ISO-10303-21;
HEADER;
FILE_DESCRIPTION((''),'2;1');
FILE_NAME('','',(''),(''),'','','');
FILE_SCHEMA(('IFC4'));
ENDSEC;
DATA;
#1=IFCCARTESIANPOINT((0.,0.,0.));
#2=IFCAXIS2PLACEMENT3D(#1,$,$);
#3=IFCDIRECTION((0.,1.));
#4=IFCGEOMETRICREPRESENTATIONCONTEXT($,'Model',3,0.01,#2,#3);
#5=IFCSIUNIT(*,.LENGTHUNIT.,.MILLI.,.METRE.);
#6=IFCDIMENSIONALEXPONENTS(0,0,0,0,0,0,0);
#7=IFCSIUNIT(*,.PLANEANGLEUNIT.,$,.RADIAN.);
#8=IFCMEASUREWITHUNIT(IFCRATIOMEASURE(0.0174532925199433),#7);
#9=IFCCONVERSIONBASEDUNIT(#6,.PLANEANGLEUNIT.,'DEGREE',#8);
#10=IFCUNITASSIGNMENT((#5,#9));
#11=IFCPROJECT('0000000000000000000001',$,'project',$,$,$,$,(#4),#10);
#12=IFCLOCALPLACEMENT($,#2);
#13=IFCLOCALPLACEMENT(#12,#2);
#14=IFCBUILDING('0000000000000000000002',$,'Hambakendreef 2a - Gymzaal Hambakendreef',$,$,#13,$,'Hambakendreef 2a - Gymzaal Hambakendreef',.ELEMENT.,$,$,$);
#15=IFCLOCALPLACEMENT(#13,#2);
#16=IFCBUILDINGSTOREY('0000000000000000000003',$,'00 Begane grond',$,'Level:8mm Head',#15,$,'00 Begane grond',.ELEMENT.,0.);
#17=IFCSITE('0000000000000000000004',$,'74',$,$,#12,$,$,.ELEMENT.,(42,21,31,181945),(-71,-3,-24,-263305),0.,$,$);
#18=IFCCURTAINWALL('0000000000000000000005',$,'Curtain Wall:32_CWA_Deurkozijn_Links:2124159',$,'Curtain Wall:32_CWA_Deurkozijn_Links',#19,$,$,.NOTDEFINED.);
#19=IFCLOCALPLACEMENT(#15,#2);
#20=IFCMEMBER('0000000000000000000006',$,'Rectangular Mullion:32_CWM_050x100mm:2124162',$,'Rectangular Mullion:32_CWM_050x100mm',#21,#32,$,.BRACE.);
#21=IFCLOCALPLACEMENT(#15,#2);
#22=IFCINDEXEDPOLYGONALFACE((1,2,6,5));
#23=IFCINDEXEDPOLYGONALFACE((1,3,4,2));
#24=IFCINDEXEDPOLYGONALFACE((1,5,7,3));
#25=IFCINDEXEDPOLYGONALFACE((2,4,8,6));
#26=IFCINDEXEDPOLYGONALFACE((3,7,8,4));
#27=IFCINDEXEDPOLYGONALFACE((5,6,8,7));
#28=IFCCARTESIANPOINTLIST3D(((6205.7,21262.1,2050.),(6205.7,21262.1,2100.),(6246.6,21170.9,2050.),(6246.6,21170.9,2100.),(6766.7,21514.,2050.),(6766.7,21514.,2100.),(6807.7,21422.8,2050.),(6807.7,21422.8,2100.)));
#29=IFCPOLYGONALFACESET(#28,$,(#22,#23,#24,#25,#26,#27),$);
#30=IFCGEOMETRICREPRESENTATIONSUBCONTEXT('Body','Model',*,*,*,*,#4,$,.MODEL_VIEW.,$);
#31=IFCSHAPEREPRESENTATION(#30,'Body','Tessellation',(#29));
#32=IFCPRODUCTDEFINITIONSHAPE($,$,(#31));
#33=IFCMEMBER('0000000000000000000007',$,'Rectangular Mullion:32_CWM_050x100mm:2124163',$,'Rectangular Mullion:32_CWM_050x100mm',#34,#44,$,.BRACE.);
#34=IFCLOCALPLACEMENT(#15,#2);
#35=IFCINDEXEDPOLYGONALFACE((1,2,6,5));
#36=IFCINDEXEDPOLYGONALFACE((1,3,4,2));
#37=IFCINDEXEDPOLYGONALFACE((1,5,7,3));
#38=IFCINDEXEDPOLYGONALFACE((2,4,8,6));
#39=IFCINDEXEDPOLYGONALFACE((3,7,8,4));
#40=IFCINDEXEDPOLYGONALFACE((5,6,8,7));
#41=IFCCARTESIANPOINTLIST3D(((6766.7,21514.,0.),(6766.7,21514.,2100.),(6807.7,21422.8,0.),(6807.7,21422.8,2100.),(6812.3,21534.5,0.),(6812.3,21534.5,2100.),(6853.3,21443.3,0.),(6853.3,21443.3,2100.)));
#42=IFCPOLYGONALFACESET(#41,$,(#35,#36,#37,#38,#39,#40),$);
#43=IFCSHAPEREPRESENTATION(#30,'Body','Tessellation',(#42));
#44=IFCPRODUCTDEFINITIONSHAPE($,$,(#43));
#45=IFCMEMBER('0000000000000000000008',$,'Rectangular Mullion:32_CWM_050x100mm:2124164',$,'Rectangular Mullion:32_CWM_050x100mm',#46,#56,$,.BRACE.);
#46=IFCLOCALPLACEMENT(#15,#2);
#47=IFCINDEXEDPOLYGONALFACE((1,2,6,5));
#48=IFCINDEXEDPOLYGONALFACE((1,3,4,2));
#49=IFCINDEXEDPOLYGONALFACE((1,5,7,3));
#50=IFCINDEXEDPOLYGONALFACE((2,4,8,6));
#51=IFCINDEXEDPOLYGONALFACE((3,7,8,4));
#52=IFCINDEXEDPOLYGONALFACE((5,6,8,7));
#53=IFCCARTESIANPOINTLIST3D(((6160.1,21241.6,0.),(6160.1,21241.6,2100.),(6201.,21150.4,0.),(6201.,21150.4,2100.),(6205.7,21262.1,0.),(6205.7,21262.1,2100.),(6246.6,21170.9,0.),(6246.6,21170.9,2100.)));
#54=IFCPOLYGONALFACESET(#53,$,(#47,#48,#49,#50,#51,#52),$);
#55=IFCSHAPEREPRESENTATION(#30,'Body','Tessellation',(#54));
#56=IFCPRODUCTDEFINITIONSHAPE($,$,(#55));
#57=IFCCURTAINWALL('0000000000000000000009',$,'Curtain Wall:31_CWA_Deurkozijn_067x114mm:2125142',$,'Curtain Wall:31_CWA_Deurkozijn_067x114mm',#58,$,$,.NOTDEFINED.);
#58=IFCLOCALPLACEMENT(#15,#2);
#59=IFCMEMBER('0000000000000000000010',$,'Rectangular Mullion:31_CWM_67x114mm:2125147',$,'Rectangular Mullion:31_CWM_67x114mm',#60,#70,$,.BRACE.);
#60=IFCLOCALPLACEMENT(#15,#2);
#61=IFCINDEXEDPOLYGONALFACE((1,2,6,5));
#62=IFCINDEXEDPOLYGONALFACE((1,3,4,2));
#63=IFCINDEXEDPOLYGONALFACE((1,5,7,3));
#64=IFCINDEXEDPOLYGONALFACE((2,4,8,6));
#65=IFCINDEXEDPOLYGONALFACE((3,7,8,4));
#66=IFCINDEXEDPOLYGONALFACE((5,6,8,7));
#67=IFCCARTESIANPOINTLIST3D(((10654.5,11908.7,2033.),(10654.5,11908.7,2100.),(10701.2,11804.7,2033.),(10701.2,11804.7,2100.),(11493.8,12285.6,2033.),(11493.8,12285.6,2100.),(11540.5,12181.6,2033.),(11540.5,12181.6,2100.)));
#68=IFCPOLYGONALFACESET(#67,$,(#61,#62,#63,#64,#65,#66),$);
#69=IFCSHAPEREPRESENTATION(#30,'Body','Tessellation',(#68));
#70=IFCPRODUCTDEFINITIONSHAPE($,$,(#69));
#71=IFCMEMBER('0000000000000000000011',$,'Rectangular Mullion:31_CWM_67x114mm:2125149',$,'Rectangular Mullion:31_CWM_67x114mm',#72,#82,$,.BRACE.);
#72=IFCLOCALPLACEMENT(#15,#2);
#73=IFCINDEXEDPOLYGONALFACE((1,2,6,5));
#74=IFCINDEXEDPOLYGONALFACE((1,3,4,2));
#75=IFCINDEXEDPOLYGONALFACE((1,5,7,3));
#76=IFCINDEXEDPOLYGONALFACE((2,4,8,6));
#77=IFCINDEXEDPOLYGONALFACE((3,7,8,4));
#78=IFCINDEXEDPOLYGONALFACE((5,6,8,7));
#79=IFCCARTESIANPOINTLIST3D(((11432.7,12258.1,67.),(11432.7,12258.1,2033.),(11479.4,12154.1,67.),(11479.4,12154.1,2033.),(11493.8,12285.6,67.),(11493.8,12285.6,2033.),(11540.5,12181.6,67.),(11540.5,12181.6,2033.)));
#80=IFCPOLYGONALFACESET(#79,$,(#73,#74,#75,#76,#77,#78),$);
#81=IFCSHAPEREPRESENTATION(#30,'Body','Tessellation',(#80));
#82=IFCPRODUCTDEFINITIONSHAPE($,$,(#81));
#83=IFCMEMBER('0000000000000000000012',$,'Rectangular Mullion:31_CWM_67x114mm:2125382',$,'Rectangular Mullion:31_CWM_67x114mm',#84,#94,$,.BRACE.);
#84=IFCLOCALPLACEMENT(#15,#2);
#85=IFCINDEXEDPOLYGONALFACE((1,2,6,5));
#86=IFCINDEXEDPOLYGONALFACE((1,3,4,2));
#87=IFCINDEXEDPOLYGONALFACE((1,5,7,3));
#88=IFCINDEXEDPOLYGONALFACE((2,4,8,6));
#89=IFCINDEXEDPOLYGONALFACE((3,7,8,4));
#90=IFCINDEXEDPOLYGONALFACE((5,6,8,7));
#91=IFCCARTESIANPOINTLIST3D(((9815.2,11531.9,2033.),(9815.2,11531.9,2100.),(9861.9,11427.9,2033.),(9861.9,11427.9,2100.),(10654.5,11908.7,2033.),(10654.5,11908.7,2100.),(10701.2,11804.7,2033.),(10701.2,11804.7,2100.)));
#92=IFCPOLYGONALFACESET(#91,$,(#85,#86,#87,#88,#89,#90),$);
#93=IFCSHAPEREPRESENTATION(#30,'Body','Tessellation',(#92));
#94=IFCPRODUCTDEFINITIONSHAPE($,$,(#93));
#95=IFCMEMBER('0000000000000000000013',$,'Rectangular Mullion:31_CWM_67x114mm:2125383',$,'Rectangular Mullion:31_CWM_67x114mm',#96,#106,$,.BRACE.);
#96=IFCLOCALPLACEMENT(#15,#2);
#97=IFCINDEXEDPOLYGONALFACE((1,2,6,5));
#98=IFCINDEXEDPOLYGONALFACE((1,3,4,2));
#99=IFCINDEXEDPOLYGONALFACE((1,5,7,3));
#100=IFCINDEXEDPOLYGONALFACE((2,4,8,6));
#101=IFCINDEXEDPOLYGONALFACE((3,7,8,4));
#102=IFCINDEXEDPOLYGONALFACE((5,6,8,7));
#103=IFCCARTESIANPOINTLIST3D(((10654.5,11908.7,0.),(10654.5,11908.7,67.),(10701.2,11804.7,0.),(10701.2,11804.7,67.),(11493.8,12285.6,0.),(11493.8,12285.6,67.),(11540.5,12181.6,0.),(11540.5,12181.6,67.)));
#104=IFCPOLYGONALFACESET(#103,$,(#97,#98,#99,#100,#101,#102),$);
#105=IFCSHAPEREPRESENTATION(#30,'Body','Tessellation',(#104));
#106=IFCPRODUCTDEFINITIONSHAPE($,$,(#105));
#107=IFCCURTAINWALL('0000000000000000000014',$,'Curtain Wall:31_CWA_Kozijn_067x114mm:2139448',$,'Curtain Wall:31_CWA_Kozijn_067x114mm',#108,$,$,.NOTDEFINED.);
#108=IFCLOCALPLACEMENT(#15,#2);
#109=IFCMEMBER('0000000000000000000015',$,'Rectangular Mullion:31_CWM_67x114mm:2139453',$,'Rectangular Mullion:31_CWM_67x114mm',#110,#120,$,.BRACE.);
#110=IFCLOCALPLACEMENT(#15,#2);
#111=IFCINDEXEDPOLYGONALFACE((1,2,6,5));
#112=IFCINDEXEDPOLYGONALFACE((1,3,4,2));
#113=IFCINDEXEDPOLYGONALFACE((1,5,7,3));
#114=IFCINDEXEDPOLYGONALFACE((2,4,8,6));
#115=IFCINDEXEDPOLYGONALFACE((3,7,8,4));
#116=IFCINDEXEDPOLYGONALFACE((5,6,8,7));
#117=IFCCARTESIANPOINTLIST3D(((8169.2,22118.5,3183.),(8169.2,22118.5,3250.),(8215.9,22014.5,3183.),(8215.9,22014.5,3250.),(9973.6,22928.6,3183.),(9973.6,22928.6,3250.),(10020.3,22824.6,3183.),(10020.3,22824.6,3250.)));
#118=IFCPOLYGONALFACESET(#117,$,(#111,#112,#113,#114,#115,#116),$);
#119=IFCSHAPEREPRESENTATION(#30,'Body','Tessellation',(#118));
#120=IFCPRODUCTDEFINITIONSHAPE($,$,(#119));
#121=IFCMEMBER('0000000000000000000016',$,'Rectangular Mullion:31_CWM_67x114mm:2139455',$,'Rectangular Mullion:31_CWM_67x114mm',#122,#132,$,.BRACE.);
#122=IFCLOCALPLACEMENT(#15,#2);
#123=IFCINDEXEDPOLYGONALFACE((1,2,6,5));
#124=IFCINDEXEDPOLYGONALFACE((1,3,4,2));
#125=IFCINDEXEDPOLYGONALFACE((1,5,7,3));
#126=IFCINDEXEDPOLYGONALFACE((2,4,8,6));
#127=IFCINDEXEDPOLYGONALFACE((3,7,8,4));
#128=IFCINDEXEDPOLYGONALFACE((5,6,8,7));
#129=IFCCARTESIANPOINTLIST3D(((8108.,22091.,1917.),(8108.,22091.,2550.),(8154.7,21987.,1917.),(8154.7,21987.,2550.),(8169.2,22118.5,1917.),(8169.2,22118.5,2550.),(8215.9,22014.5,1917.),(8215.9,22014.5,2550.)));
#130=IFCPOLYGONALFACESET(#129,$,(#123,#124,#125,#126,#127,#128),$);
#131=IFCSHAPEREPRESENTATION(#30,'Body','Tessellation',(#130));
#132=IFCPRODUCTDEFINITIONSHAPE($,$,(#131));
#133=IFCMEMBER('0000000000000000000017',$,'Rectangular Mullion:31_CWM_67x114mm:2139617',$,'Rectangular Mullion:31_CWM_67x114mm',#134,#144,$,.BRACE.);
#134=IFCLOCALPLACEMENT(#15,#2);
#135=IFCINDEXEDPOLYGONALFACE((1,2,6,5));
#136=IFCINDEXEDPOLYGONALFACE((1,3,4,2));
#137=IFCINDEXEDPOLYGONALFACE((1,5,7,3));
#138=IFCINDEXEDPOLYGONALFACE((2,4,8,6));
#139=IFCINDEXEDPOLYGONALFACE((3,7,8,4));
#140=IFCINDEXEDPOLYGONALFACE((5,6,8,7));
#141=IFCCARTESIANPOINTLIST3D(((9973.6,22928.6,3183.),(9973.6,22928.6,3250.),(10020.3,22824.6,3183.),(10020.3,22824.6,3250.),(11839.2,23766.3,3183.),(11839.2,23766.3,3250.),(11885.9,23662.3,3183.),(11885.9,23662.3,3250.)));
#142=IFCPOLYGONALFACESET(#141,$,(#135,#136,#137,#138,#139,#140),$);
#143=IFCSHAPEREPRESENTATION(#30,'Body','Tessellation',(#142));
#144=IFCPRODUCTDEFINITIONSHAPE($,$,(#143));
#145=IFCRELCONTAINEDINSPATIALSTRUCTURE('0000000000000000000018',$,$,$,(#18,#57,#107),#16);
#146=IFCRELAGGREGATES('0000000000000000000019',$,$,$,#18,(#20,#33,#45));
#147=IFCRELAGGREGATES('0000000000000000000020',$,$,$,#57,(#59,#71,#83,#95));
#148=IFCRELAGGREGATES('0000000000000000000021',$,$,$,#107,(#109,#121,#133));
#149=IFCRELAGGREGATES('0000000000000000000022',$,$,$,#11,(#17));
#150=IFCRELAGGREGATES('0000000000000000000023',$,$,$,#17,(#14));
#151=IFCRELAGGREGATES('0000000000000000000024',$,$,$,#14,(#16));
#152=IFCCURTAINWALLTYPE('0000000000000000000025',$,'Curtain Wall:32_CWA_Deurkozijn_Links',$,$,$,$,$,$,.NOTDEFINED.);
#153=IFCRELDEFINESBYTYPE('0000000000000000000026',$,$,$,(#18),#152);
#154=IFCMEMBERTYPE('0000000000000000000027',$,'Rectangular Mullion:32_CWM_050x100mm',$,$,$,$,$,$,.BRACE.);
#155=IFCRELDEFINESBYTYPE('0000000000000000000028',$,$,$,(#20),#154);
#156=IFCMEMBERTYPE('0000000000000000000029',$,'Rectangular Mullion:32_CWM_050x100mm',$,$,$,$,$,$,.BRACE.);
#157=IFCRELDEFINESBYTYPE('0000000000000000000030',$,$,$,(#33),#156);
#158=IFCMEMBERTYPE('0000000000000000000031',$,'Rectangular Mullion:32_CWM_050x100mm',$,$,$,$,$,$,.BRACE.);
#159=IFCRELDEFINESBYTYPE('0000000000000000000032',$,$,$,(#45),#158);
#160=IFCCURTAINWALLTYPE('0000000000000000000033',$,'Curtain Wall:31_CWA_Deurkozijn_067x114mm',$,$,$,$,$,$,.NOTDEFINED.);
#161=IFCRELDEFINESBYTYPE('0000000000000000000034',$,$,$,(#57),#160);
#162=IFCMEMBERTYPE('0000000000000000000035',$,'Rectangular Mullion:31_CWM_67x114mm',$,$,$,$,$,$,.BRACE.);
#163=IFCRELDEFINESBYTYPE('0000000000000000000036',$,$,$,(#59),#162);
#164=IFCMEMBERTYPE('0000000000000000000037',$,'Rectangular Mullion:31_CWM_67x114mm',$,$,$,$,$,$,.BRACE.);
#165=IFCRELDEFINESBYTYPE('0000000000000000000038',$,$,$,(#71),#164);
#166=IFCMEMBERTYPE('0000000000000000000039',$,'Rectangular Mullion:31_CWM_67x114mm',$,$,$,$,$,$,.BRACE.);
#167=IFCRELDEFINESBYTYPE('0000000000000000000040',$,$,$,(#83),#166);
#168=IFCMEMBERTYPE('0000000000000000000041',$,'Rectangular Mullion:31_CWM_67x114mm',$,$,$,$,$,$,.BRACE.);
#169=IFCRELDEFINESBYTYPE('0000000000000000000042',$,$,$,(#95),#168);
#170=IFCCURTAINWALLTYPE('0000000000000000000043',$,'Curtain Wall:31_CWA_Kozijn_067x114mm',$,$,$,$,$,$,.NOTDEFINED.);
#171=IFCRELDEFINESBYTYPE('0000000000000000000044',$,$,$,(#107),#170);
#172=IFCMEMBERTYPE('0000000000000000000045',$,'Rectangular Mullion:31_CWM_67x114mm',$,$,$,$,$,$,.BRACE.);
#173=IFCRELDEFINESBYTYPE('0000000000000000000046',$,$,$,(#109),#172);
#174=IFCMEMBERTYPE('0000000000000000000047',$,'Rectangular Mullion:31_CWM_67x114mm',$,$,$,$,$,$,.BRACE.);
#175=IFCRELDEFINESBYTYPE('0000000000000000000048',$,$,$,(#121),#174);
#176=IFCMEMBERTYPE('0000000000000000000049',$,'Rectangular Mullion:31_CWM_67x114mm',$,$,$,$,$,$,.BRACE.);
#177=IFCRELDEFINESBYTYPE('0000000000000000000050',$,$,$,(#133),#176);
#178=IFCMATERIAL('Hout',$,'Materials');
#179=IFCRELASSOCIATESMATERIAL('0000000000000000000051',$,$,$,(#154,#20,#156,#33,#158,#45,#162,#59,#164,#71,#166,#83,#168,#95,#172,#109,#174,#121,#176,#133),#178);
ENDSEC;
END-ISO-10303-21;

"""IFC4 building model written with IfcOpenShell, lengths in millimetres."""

from ifc_helpers import new_model, entity, si_unit, converted_unit, direction, frame, origin, place, context, subcontext, project, spatial, indexed_curve, outline, extrude, source, transform, mapped, material, type_object, type_shapes, element, aggregate, save


model = new_model("IFC4")

# Units and contexts
model_context = context("Model", 3, precision=0.01, world=origin(), true_north=direction((0.0, 1.0)))
body_context = subcontext(model_context, "Body", "Model", "MODEL_VIEW")
ifc_project = project(units=[si_unit("LENGTHUNIT", "METRE", prefix="MILLI"), converted_unit("PLANEANGLEUNIT", "DEGREE", entity("IfcRatioMeasure", 0.0174532925199433), si_unit("PLANEANGLEUNIT", "RADIAN"), dimensions=[0, 0, 0, 0, 0, 0, 0])], contexts=[model_context])

# Site, building, storey
site_placement = place(None, origin())
site = spatial("IfcSite", under=ifc_project, at=site_placement, Name="74", CompositionType="ELEMENT", RefLatitude=(42, 21, 31, 181945), RefLongitude=(-71, -3, -24, -263305), RefElevation=0.0)
building_placement = place(site_placement, origin())
building = spatial("IfcBuilding", under=site, at=building_placement, Name="Hambakendreef 2a - Gymzaal Hambakendreef", LongName="Hambakendreef 2a - Gymzaal Hambakendreef", CompositionType="ELEMENT")
storey_placement = place(building_placement, origin())
storey = spatial("IfcBuildingStorey", under=building, at=storey_placement, Name="00 Begane grond", ObjectType="Level:8mm Head", LongName="00 Begane grond", CompositionType="ELEMENT", Elevation=0.0)

# Curtain walls, members
curtain_wall_type_1 = type_object("IfcCurtainWallType", Name="Curtain Wall:32_CWA_Deurkozijn_Links", PredefinedType="NOTDEFINED")
curtain_wall_1_placement = place(storey_placement, origin())
curtain_wall_1 = element("IfcCurtainWall", 1, at=curtain_wall_1_placement, inside=storey, type_object=curtain_wall_type_1, Name="Curtain Wall:32_CWA_Deurkozijn_Links:2124159", ObjectType="Curtain Wall:32_CWA_Deurkozijn_Links", PredefinedType="NOTDEFINED")
ifc_material_1 = material(Name="Hout", Category="Materials")
member_type_1 = type_object("IfcMemberType", Name="Rectangular Mullion:32_CWM_050x100mm", PredefinedType="BRACE", material=ifc_material_1)
shared_shape_1 = source(origin(), body_context, "Body", "SweptSolid", [
    extrude(outline(indexed_curve([(-50.0, -25.0), (50.0, -25.0), (50.0, 25.0), (-50.0, 25.0), (-50.0, -25.0)], self_intersect=False)), frame((-25.0, 0.0, -615.0), z_axis=(0.0, 0.0, 1.0), x_axis=(0.0, -1.0, 0.0)), (0.0, 0.0, 1.0), 615.0),
])
type_shapes(member_type_1, [shared_shape_1])
member_1_placement = place(storey_placement, frame((6787.2, 21468.4, 2100.0), z_axis=(0.91227, 0.40959, 0.0), x_axis=(0.0, 0.0, 1.0)))
member_1 = element("IfcMember", 2, at=member_1_placement, type_object=member_type_1, material=ifc_material_1, Name="Rectangular Mullion:32_CWM_050x100mm:2124162", ObjectType="Rectangular Mullion:32_CWM_050x100mm", PredefinedType="BRACE", context=body_context, shape_type="MappedRepresentation", body=[
    mapped(shared_shape_1, transform((0.0, 0.0, 0.0), scale=1.0)),
])
member_type_2 = type_object("IfcMemberType", Name="Rectangular Mullion:32_CWM_050x100mm", PredefinedType="BRACE", material=ifc_material_1)
shared_shape_2 = source(origin(), body_context, "Body", "SweptSolid", [
    extrude(outline(indexed_curve([(-50.0, -25.0), (50.0, -25.0), (50.0, 25.0), (-50.0, 25.0), (-50.0, -25.0)], self_intersect=False)), frame((-25.0, 0.0, -2100.0), z_axis=(0.0, 0.0, 1.0), x_axis=(0.0, -1.0, 0.0)), (0.0, 0.0, 1.0), 2100.0),
])
type_shapes(member_type_2, [shared_shape_2])
member_2_placement = place(storey_placement, frame((6832.8, 21488.9, 0.0), z_axis=(0.0, 0.0, -1.0), x_axis=(0.91227, 0.40959, 0.0)))
member_2 = element("IfcMember", 3, at=member_2_placement, type_object=member_type_2, material=ifc_material_1, Name="Rectangular Mullion:32_CWM_050x100mm:2124163", ObjectType="Rectangular Mullion:32_CWM_050x100mm", PredefinedType="BRACE", context=body_context, shape_type="MappedRepresentation", body=[
    mapped(shared_shape_2, transform((0.0, 0.0, 0.0), scale=1.0)),
])
member_type_3 = type_object("IfcMemberType", Name="Rectangular Mullion:32_CWM_050x100mm", PredefinedType="BRACE", material=ifc_material_1)
shared_shape_3 = source(origin(), body_context, "Body", "SweptSolid", [
    extrude(outline(indexed_curve([(-50.0, -25.0), (50.0, -25.0), (50.0, 25.0), (-50.0, 25.0), (-50.0, -25.0)], self_intersect=False)), frame((-25.0, 0.0, -2100.0), z_axis=(0.0, 0.0, 1.0), x_axis=(0.0, -1.0, 0.0)), (0.0, 0.0, 1.0), 2100.0),
])
type_shapes(member_type_3, [shared_shape_3])
member_3_placement = place(storey_placement, frame((6180.5, 21196.0, 2100.0), z_axis=(0.0, 0.0, 1.0), x_axis=(-0.91227, -0.40959, 0.0)))
member_3 = element("IfcMember", 4, at=member_3_placement, type_object=member_type_3, material=ifc_material_1, Name="Rectangular Mullion:32_CWM_050x100mm:2124164", ObjectType="Rectangular Mullion:32_CWM_050x100mm", PredefinedType="BRACE", context=body_context, shape_type="MappedRepresentation", body=[
    mapped(shared_shape_3, transform((0.0, 0.0, 0.0), scale=1.0)),
])
curtain_wall_type_2 = type_object("IfcCurtainWallType", Name="Curtain Wall:31_CWA_Deurkozijn_067x114mm", PredefinedType="NOTDEFINED")
curtain_wall_2_placement = place(storey_placement, origin())
curtain_wall_2 = element("IfcCurtainWall", 5, at=curtain_wall_2_placement, inside=storey, type_object=curtain_wall_type_2, Name="Curtain Wall:31_CWA_Deurkozijn_067x114mm:2125142", ObjectType="Curtain Wall:31_CWA_Deurkozijn_067x114mm", PredefinedType="NOTDEFINED")
member_type_4 = type_object("IfcMemberType", Name="Rectangular Mullion:31_CWM_67x114mm", PredefinedType="BRACE", material=ifc_material_1)
shared_shape_4 = source(origin(), body_context, "Body", "SweptSolid", [
    extrude(outline(indexed_curve([(-57.0, -33.5), (57.0, -33.5), (57.0, 33.5), (-57.0, 33.5), (-57.0, -33.5)], self_intersect=False)), frame((-33.5, 0.0, -920.0), z_axis=(0.0, 0.0, 1.0), x_axis=(0.0, -1.0, 0.0)), (0.0, 0.0, 1.0), 920.0),
])
type_shapes(member_type_4, [shared_shape_4])
member_4_placement = place(storey_placement, frame((11517.1, 12233.6, 2100.0), z_axis=(0.91227, 0.40959, 0.0), x_axis=(0.0, 0.0, 1.0)))
member_4 = element("IfcMember", 6, at=member_4_placement, type_object=member_type_4, material=ifc_material_1, Name="Rectangular Mullion:31_CWM_67x114mm:2125147", ObjectType="Rectangular Mullion:31_CWM_67x114mm", PredefinedType="BRACE", context=body_context, shape_type="MappedRepresentation", body=[
    mapped(shared_shape_4, transform((0.0, 0.0, 0.0), scale=1.0)),
])
member_type_5 = type_object("IfcMemberType", Name="Rectangular Mullion:31_CWM_67x114mm", PredefinedType="BRACE", material=ifc_material_1)
shared_shape_5 = source(origin(), body_context, "Body", "SweptSolid", [
    extrude(outline(indexed_curve([(-57.0, -33.5), (57.0, -33.5), (57.0, 33.5), (-57.0, 33.5), (-57.0, -33.5)], self_intersect=False)), frame((-33.5, 0.0, -1966.0), z_axis=(0.0, 0.0, 1.0), x_axis=(0.0, -1.0, 0.0)), (0.0, 0.0, 1.0), 1966.0),
])
type_shapes(member_type_5, [shared_shape_5])
member_5_placement = place(storey_placement, frame((11517.1, 12233.6, 67.0), z_axis=(0.0, 0.0, -1.0), x_axis=(0.91227, 0.40959, 0.0)))
member_5 = element("IfcMember", 7, at=member_5_placement, type_object=member_type_5, material=ifc_material_1, Name="Rectangular Mullion:31_CWM_67x114mm:2125149", ObjectType="Rectangular Mullion:31_CWM_67x114mm", PredefinedType="BRACE", context=body_context, shape_type="MappedRepresentation", body=[
    mapped(shared_shape_5, transform((0.0, 0.0, 0.0), scale=1.0)),
])
member_type_6 = type_object("IfcMemberType", Name="Rectangular Mullion:31_CWM_67x114mm", PredefinedType="BRACE", material=ifc_material_1)
shared_shape_6 = source(origin(), body_context, "Body", "SweptSolid", [
    extrude(outline(indexed_curve([(-57.0, -33.5), (57.0, -33.5), (57.0, 33.5), (-57.0, 33.5), (-57.0, -33.5)], self_intersect=False)), frame((-33.5, 0.0, -920.0), z_axis=(0.0, 0.0, 1.0), x_axis=(0.0, -1.0, 0.0)), (0.0, 0.0, 1.0), 920.0),
])
type_shapes(member_type_6, [shared_shape_6])
member_6_placement = place(storey_placement, frame((10677.9, 11856.7, 2100.0), z_axis=(0.91227, 0.40959, 0.0), x_axis=(0.0, 0.0, 1.0)))
member_6 = element("IfcMember", 8, at=member_6_placement, type_object=member_type_6, material=ifc_material_1, Name="Rectangular Mullion:31_CWM_67x114mm:2125382", ObjectType="Rectangular Mullion:31_CWM_67x114mm", PredefinedType="BRACE", context=body_context, shape_type="MappedRepresentation", body=[
    mapped(shared_shape_6, transform((0.0, 0.0, 0.0), scale=1.0)),
])
member_type_7 = type_object("IfcMemberType", Name="Rectangular Mullion:31_CWM_67x114mm", PredefinedType="BRACE", material=ifc_material_1)
shared_shape_7 = source(origin(), body_context, "Body", "SweptSolid", [
    extrude(outline(indexed_curve([(-57.0, -33.5), (57.0, -33.5), (57.0, 33.5), (-57.0, 33.5), (-57.0, -33.5)], self_intersect=False)), frame((-33.5, 0.0, -920.0), z_axis=(0.0, 0.0, 1.0), x_axis=(0.0, -1.0, 0.0)), (0.0, 0.0, 1.0), 920.0),
])
type_shapes(member_type_7, [shared_shape_7])
member_7_placement = place(storey_placement, frame((10677.9, 11856.7, 0.0), z_axis=(-0.91227, -0.40959, 0.0), x_axis=(0.0, 0.0, -1.0)))
member_7 = element("IfcMember", 9, at=member_7_placement, type_object=member_type_7, material=ifc_material_1, Name="Rectangular Mullion:31_CWM_67x114mm:2125383", ObjectType="Rectangular Mullion:31_CWM_67x114mm", PredefinedType="BRACE", context=body_context, shape_type="MappedRepresentation", body=[
    mapped(shared_shape_7, transform((0.0, 0.0, 0.0), scale=1.0)),
])
curtain_wall_type_3 = type_object("IfcCurtainWallType", Name="Curtain Wall:31_CWA_Kozijn_067x114mm", PredefinedType="NOTDEFINED")
curtain_wall_3_placement = place(storey_placement, origin())
curtain_wall_3 = element("IfcCurtainWall", 10, at=curtain_wall_3_placement, inside=storey, type_object=curtain_wall_type_3, Name="Curtain Wall:31_CWA_Kozijn_067x114mm:2139448", ObjectType="Curtain Wall:31_CWA_Kozijn_067x114mm", PredefinedType="NOTDEFINED")
member_type_8 = type_object("IfcMemberType", Name="Rectangular Mullion:31_CWM_67x114mm", PredefinedType="BRACE", material=ifc_material_1)
shared_shape_8 = source(origin(), body_context, "Body", "SweptSolid", [
    extrude(outline(indexed_curve([(-57.0, -33.5), (57.0, -33.5), (57.0, 33.5), (-57.0, 33.5), (-57.0, -33.5)], self_intersect=False)), frame((-33.5, 0.0, -1978.0), z_axis=(0.0, 0.0, 1.0), x_axis=(0.0, -1.0, 0.0)), (0.0, 0.0, 1.0), 1978.0),
])
type_shapes(member_type_8, [shared_shape_8])
member_8_placement = place(storey_placement, frame((8192.5, 22066.5, 3250.0), z_axis=(-0.91227, -0.40959, 0.0), x_axis=(0.0, 0.0, 1.0)))
member_8 = element("IfcMember", 11, at=member_8_placement, type_object=member_type_8, material=ifc_material_1, Name="Rectangular Mullion:31_CWM_67x114mm:2139453", ObjectType="Rectangular Mullion:31_CWM_67x114mm", PredefinedType="BRACE", context=body_context, shape_type="MappedRepresentation", body=[
    mapped(shared_shape_8, transform((0.0, 0.0, 0.0), scale=1.0)),
])
member_type_9 = type_object("IfcMemberType", Name="Rectangular Mullion:31_CWM_67x114mm", PredefinedType="BRACE", material=ifc_material_1)
shared_shape_9 = source(origin(), body_context, "Body", "SweptSolid", [
    extrude(outline(indexed_curve([(-57.0, -33.5), (57.0, -33.5), (57.0, 33.5), (-57.0, 33.5), (-57.0, -33.5)], self_intersect=False)), frame((-33.5, 0.0, -633.0), z_axis=(0.0, 0.0, 1.0), x_axis=(0.0, -1.0, 0.0)), (0.0, 0.0, 1.0), 633.0),
])
type_shapes(member_type_9, [shared_shape_9])
member_9_placement = place(storey_placement, frame((8131.4, 22039.0, 1917.0), z_axis=(0.0, 0.0, -1.0), x_axis=(-0.91227, -0.40959, 0.0)))
member_9 = element("IfcMember", 12, at=member_9_placement, type_object=member_type_9, material=ifc_material_1, Name="Rectangular Mullion:31_CWM_67x114mm:2139455", ObjectType="Rectangular Mullion:31_CWM_67x114mm", PredefinedType="BRACE", context=body_context, shape_type="MappedRepresentation", body=[
    mapped(shared_shape_9, transform((0.0, 0.0, 0.0), scale=1.0)),
])
member_type_10 = type_object("IfcMemberType", Name="Rectangular Mullion:31_CWM_67x114mm", PredefinedType="BRACE", material=ifc_material_1)
shared_shape_10 = source(origin(), body_context, "Body", "SweptSolid", [
    extrude(outline(indexed_curve([(-57.0, -33.5), (57.0, -33.5), (57.0, 33.5), (-57.0, 33.5), (-57.0, -33.5)], self_intersect=False)), frame((-33.5, 0.0, -2045.0), z_axis=(0.0, 0.0, 1.0), x_axis=(0.0, -1.0, 0.0)), (0.0, 0.0, 1.0), 2045.0),
])
type_shapes(member_type_10, [shared_shape_10])
member_10_placement = place(storey_placement, frame((9997.0, 22876.6, 3250.0), z_axis=(-0.91227, -0.40959, 0.0), x_axis=(0.0, 0.0, 1.0)))
member_10 = element("IfcMember", 13, at=member_10_placement, type_object=member_type_10, material=ifc_material_1, Name="Rectangular Mullion:31_CWM_67x114mm:2139617", ObjectType="Rectangular Mullion:31_CWM_67x114mm", PredefinedType="BRACE", context=body_context, shape_type="MappedRepresentation", body=[
    mapped(shared_shape_10, transform((0.0, 0.0, 0.0), scale=1.0)),
])

aggregate(curtain_wall_1, [member_1, member_2, member_3])
aggregate(curtain_wall_2, [member_4, member_5, member_6, member_7])

aggregate(curtain_wall_3, [member_8, member_9, member_10])

save(model, "model.ifc")
